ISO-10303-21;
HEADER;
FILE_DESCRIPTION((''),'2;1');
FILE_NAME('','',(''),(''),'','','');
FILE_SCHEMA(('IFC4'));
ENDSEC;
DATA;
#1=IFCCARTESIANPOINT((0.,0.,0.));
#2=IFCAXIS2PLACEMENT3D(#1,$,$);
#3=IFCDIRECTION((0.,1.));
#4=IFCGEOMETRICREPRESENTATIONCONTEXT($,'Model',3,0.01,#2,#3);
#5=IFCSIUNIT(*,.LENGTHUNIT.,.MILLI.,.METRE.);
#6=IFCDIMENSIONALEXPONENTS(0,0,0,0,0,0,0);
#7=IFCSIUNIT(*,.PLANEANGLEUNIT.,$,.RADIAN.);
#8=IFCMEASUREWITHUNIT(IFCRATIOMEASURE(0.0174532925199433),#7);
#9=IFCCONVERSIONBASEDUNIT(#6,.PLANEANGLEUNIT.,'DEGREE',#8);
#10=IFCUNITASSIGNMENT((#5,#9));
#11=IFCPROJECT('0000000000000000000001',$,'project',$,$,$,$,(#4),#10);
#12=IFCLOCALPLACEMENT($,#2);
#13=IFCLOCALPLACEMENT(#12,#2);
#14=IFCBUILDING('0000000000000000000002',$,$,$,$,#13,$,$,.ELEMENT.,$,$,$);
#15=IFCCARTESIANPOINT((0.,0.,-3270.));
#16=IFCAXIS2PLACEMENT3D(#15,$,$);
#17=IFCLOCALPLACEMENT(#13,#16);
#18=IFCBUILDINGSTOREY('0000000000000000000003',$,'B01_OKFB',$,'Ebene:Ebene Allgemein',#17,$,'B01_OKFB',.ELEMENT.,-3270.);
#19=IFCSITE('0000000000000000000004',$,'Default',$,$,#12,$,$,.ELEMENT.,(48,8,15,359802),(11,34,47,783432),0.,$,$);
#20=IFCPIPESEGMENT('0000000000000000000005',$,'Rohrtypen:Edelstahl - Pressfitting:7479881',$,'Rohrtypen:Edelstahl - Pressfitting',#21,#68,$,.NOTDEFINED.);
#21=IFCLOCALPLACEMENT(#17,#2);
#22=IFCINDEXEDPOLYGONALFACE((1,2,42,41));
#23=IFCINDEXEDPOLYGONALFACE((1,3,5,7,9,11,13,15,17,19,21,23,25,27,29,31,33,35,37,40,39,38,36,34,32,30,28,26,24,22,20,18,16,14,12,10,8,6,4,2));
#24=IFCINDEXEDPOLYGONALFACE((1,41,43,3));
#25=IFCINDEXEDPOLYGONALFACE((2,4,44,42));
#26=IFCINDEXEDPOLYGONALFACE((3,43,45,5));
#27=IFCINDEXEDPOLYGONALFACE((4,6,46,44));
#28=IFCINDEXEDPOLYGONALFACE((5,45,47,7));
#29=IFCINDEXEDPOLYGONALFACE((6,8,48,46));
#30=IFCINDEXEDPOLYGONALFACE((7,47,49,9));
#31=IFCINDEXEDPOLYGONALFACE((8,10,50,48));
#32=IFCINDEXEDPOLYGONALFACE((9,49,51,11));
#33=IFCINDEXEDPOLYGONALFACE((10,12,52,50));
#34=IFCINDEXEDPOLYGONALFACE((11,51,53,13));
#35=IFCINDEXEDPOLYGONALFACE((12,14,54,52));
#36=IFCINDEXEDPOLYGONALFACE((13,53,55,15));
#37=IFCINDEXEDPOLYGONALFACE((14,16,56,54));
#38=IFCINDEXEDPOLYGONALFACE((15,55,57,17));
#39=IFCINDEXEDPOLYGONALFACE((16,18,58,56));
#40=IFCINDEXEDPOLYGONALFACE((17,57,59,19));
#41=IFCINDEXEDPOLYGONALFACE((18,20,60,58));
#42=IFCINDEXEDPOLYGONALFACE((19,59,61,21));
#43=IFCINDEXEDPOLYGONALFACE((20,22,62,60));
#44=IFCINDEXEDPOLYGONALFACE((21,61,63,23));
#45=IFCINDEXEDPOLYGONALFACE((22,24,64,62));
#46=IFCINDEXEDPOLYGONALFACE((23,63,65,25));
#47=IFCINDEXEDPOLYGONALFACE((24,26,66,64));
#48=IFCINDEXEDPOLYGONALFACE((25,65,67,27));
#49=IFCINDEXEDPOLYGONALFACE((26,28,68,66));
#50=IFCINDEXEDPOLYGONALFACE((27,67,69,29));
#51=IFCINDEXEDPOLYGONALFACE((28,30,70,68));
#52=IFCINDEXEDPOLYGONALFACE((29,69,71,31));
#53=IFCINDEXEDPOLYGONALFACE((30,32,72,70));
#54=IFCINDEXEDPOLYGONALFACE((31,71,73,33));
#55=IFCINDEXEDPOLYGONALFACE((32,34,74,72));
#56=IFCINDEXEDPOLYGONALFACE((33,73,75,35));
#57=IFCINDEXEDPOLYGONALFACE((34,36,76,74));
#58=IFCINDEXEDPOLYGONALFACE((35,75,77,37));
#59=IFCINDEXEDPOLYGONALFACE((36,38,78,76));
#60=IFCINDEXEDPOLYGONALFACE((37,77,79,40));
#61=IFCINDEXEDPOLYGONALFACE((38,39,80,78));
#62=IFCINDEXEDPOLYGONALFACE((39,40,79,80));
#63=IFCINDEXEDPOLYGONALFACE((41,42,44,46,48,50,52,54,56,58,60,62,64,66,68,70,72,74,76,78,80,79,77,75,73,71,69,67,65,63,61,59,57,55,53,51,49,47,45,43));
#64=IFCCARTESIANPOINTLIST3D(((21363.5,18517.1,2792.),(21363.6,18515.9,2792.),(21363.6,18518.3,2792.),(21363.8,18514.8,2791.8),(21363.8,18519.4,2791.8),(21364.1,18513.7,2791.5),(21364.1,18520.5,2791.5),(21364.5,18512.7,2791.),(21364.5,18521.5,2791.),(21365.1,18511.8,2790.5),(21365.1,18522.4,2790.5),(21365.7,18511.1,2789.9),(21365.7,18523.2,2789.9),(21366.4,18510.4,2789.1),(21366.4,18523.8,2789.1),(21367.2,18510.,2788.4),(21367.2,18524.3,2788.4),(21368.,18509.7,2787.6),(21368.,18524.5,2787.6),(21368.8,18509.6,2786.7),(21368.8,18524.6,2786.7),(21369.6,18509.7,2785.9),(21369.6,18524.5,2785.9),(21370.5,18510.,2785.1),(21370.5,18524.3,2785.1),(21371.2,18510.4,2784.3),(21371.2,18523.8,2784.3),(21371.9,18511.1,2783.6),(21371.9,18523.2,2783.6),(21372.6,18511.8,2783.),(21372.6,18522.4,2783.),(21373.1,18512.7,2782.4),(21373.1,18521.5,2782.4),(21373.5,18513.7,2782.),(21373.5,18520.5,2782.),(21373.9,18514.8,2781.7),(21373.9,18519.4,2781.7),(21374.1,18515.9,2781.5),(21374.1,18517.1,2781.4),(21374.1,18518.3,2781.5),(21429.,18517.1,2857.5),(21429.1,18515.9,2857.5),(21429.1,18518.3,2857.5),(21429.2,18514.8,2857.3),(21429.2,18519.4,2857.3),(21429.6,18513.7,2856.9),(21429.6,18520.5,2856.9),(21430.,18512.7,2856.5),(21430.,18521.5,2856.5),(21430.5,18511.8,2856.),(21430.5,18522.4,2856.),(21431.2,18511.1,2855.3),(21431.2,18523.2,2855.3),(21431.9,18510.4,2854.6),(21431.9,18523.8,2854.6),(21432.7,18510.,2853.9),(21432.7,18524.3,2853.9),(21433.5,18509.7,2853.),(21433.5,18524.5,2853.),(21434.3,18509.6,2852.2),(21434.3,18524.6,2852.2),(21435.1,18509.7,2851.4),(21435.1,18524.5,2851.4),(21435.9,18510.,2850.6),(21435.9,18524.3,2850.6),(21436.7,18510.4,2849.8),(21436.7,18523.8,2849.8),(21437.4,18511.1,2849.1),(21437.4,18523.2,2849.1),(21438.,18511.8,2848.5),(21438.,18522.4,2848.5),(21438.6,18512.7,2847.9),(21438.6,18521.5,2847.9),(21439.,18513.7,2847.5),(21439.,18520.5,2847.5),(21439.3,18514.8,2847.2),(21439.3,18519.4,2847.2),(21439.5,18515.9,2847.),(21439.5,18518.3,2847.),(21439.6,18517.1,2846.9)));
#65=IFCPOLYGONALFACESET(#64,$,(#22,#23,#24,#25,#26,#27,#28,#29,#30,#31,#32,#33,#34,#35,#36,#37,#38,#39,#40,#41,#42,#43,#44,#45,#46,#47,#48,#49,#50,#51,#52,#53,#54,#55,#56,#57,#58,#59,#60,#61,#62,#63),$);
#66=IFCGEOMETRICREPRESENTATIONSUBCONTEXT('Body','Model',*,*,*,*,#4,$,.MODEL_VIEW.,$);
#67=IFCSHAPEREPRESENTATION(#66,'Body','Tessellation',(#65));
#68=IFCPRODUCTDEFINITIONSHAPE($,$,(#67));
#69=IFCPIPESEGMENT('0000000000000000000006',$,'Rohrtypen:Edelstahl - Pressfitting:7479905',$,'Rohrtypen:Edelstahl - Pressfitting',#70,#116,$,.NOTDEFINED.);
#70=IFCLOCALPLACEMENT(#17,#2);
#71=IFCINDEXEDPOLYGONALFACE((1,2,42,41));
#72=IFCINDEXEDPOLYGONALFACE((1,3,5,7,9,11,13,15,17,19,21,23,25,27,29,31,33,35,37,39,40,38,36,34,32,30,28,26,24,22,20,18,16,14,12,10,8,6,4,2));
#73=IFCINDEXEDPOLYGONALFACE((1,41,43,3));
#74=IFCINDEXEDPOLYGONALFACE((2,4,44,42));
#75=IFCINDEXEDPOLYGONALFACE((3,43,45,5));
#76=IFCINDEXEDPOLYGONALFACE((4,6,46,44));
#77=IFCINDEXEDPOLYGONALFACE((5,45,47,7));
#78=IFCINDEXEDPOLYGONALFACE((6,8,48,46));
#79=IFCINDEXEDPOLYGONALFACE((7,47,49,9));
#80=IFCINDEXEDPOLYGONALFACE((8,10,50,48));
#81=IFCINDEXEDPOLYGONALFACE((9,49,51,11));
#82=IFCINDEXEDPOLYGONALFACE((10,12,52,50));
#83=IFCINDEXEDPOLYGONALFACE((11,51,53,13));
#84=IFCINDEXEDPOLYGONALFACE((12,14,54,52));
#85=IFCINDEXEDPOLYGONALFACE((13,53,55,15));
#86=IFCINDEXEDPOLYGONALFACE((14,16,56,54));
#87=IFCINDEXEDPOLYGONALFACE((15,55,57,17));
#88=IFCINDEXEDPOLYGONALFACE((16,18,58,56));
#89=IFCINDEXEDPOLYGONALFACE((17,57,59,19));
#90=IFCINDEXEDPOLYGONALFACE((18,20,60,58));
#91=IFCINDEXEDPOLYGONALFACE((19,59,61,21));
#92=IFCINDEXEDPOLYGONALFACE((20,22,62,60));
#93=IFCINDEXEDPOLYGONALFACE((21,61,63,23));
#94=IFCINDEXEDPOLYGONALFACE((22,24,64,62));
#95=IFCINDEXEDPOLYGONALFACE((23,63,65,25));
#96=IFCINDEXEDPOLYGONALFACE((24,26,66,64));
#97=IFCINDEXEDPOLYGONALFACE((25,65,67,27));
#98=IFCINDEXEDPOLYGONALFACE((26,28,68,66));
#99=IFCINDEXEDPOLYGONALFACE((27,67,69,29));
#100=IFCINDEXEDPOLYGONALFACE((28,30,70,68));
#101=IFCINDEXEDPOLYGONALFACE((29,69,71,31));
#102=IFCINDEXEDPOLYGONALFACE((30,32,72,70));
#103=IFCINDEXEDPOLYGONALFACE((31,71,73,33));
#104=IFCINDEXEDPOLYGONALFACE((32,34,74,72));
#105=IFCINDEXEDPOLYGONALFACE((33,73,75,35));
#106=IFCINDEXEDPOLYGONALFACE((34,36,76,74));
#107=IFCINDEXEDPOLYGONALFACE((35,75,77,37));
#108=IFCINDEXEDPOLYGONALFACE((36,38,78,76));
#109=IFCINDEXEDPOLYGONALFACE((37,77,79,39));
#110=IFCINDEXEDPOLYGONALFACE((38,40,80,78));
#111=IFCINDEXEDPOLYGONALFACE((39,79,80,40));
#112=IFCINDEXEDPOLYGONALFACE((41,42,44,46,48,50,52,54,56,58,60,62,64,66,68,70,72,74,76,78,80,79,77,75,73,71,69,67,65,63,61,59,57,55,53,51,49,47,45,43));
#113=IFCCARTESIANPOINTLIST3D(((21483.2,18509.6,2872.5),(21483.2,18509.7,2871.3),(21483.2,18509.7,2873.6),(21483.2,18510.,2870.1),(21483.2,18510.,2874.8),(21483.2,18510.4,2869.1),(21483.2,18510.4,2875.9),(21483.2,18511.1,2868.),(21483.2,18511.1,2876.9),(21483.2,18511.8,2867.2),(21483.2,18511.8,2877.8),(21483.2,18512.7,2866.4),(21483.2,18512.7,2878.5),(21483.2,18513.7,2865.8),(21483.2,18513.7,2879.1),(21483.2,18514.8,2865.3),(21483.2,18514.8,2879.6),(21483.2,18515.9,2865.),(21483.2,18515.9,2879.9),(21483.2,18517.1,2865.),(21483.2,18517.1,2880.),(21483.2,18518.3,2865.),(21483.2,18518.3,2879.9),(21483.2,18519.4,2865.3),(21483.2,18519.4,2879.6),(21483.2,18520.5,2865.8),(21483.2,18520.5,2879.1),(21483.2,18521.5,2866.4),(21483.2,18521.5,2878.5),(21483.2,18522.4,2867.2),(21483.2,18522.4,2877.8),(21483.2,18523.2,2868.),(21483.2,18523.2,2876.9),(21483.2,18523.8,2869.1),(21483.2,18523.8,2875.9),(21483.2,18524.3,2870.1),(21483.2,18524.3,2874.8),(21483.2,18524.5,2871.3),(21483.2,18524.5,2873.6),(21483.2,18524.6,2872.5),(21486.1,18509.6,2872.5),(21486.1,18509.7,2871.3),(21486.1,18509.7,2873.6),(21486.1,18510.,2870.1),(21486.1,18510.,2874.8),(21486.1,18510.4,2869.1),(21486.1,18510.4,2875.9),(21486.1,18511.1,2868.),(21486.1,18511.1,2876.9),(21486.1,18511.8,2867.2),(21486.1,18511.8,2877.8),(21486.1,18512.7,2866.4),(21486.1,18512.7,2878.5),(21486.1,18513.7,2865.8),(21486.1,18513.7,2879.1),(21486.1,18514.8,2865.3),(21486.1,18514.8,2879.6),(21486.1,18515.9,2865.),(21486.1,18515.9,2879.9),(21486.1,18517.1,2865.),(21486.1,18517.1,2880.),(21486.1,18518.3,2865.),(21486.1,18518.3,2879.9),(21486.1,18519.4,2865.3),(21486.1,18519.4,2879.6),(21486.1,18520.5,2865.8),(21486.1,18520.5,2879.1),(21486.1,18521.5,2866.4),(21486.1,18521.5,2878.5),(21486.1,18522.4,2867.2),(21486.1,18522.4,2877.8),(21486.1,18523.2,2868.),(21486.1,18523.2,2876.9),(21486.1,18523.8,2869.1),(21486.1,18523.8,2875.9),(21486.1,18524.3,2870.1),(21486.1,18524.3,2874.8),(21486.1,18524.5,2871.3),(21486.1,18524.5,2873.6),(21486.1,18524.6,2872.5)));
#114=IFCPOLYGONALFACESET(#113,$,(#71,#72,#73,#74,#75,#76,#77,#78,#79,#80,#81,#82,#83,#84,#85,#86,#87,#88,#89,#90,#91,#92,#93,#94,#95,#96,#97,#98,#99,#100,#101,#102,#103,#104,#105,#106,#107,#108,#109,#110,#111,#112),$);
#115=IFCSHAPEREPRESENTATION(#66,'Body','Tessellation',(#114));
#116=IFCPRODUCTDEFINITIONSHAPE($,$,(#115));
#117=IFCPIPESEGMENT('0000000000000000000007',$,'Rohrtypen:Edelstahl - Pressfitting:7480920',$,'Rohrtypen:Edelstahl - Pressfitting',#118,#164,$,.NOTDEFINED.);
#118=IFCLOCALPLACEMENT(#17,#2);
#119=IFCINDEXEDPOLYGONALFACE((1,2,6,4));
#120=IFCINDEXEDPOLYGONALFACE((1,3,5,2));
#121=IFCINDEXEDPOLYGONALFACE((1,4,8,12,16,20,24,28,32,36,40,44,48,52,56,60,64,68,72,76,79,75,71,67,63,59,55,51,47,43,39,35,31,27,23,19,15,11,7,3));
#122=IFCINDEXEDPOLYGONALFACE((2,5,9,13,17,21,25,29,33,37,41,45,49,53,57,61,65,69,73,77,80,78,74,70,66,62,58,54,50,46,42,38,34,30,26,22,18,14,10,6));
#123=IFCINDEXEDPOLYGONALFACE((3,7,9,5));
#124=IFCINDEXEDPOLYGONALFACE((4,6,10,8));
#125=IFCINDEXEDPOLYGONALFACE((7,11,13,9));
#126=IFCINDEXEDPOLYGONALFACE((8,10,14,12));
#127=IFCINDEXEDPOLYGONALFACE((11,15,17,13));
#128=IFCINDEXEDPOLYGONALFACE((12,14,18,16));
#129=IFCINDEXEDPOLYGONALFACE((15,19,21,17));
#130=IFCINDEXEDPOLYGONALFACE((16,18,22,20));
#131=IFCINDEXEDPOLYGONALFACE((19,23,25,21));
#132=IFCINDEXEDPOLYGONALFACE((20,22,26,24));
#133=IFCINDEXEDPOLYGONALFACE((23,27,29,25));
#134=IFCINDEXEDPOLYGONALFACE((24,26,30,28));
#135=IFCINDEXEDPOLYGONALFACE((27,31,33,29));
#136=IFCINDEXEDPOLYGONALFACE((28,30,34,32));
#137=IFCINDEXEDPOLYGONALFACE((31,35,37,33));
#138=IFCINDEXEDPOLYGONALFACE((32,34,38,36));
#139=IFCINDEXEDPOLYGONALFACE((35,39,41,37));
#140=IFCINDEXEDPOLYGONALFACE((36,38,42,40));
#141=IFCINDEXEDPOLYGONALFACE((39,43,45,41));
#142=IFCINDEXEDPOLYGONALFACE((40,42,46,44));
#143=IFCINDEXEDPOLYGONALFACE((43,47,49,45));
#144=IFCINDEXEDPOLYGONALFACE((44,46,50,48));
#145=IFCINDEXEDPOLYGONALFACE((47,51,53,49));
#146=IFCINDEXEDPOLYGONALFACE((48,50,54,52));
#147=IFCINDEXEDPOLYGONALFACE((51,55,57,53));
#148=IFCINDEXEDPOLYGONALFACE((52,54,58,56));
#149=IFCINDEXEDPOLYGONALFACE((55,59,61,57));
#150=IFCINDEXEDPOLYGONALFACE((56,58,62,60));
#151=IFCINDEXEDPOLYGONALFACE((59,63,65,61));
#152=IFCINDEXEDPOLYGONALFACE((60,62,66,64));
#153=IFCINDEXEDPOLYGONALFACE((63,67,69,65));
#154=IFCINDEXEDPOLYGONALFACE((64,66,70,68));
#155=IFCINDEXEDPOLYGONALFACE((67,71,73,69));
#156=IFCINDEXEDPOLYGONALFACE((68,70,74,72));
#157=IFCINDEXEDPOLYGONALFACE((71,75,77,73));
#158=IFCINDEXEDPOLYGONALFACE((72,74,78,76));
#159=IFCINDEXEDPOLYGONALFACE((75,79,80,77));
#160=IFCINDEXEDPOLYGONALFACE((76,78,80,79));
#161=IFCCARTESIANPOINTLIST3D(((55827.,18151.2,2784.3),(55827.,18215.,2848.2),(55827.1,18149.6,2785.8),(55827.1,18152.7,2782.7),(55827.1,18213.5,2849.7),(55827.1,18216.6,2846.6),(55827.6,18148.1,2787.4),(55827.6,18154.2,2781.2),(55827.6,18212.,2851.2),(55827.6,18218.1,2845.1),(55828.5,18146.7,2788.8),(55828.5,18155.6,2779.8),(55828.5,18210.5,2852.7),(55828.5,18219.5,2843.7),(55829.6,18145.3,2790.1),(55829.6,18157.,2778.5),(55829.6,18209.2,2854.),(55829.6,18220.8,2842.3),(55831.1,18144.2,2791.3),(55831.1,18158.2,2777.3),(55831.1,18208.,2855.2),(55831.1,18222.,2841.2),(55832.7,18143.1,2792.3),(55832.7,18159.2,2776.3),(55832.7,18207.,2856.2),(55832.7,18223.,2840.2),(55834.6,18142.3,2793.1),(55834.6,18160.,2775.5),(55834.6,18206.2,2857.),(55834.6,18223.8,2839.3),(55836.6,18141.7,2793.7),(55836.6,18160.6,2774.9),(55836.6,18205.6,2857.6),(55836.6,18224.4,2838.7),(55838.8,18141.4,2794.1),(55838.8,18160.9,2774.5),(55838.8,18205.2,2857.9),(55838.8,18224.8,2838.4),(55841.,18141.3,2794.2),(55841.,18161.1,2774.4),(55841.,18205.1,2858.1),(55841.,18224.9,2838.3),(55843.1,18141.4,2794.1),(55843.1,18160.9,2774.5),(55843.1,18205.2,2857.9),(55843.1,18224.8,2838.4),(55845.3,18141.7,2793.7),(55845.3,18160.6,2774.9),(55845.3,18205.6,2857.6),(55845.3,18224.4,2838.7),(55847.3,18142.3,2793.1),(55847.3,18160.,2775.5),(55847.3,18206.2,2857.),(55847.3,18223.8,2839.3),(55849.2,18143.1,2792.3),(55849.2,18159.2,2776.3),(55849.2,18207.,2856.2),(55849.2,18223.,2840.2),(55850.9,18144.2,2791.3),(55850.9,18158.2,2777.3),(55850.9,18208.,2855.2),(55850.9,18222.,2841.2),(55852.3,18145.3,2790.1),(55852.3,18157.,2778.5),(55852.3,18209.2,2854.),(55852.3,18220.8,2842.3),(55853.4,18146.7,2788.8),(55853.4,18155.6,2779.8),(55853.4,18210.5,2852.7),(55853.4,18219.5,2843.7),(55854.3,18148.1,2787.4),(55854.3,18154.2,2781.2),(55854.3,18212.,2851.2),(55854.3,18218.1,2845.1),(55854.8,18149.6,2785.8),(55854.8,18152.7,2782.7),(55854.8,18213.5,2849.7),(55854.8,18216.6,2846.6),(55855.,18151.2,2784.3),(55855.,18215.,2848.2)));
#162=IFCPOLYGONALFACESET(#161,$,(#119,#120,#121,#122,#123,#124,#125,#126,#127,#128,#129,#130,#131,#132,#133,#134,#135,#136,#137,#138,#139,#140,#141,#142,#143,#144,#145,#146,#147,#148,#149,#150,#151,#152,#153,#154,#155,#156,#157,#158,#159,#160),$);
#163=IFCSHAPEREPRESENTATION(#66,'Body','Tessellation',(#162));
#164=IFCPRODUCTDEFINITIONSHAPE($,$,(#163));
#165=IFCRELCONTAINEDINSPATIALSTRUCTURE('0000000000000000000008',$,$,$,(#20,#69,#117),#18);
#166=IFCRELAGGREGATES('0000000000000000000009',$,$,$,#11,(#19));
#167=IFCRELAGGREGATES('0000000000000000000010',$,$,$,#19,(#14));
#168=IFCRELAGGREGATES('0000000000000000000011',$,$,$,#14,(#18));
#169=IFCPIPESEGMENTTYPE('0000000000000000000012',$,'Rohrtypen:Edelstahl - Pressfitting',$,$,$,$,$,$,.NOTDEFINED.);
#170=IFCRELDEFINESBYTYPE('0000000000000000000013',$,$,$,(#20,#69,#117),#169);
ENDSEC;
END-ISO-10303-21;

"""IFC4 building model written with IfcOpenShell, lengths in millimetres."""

from ifc_helpers import new_model, entity, si_unit, converted_unit, direction, frame, origin, place, context, subcontext, project, spatial, indexed_curve, outline, extrude, type_object, element, save


model = new_model("IFC4")

# Units and contexts
model_context = context("Model", 3, precision=0.01, world=origin(), true_north=direction((0.0, 1.0)))
body_context = subcontext(model_context, "Body", "Model", "MODEL_VIEW")
ifc_project = project(units=[si_unit("LENGTHUNIT", "METRE", prefix="MILLI"), converted_unit("PLANEANGLEUNIT", "DEGREE", entity("IfcRatioMeasure", 0.0174532925199433), si_unit("PLANEANGLEUNIT", "RADIAN"), dimensions=[0, 0, 0, 0, 0, 0, 0])], contexts=[model_context])

# Site, building, storey
site_placement = place(None, origin())
site = spatial("IfcSite", under=ifc_project, at=site_placement, Name="Default", CompositionType="ELEMENT", RefLatitude=(48, 8, 15, 359802), RefLongitude=(11, 34, 47, 783432), RefElevation=0.0)
building_placement = place(site_placement, origin())
building = spatial("IfcBuilding", under=site, at=building_placement, CompositionType="ELEMENT")
storey_placement = place(building_placement, frame((0.0, 0.0, -3270.0)))
storey = spatial("IfcBuildingStorey", under=building, at=storey_placement, Name="B01_OKFB", ObjectType="Ebene:Ebene Allgemein", LongName="B01_OKFB", CompositionType="ELEMENT", Elevation=-3270.0)

# Pipe segments
pipe_segment_type_1 = type_object("IfcPipeSegmentType", Name="Rohrtypen:Edelstahl - Pressfitting", PredefinedType="NOTDEFINED")
pipe_segment_1_placement = place(storey_placement, origin())
element("IfcPipeSegment", 1, at=pipe_segment_1_placement, inside=storey, type_object=pipe_segment_type_1, Name="Rohrtypen:Edelstahl - Pressfitting:7479881", ObjectType="Rohrtypen:Edelstahl - Pressfitting", PredefinedType="NOTDEFINED", context=body_context, shape_type="SweptSolid", body=[
    extrude(outline(indexed_curve([(7.5, 0.0), (7.4, 1.2), (7.1, 2.3), (6.7, 3.4), (6.1, 4.4), (5.3, 5.3), (4.4, 6.1), (3.4, 6.7), (2.3, 7.1), (1.2, 7.4), (0.0, 7.5), (-1.2, 7.4), (-2.3, 7.1), (-3.4, 6.7), (-4.4, 6.1), (-5.3, 5.3), (-6.1, 4.4), (-6.7, 3.4), (-7.1, 2.3), (-7.4, 1.2), (-7.5, 0.0), (-7.4, -1.2), (-7.1, -2.3), (-6.7, -3.4), (-6.1, -4.4), (-5.3, -5.3), (-4.4, -6.1), (-3.4, -6.7), (-2.3, -7.1), (-1.2, -7.4), (0.0, -7.5), (1.2, -7.4), (2.3, -7.1), (3.4, -6.7), (4.4, -6.1), (5.3, -5.3), (6.1, -4.4), (6.7, -3.4), (7.1, -2.3), (7.4, -1.2), (7.5, 0.0)], self_intersect=False)), frame((21368.8, 18517.1, 2786.7), z_axis=(0.707107, 0.0, 0.707107), x_axis=(0.0, -1.0, 0.0)), (0.0, 0.0, 1.0), 92.6),
])
pipe_segment_2_placement = place(storey_placement, origin())
element("IfcPipeSegment", 2, at=pipe_segment_2_placement, inside=storey, type_object=pipe_segment_type_1, Name="Rohrtypen:Edelstahl - Pressfitting:7479905", ObjectType="Rohrtypen:Edelstahl - Pressfitting", PredefinedType="NOTDEFINED", context=body_context, shape_type="SweptSolid", body=[
    extrude(outline(indexed_curve([(7.5, 0.0), (7.4, 1.2), (7.1, 2.3), (6.7, 3.4), (6.1, 4.4), (5.3, 5.3), (4.4, 6.1), (3.4, 6.7), (2.3, 7.1), (1.2, 7.4), (0.0, 7.5), (-1.2, 7.4), (-2.3, 7.1), (-3.4, 6.7), (-4.4, 6.1), (-5.3, 5.3), (-6.1, 4.4), (-6.7, 3.4), (-7.1, 2.3), (-7.4, 1.2), (-7.5, 0.0), (-7.4, -1.2), (-7.1, -2.3), (-6.7, -3.4), (-6.1, -4.4), (-5.3, -5.3), (-4.4, -6.1), (-3.4, -6.7), (-2.3, -7.1), (-1.2, -7.4), (0.0, -7.5), (1.2, -7.4), (2.3, -7.1), (3.4, -6.7), (4.4, -6.1), (5.3, -5.3), (6.1, -4.4), (6.7, -3.4), (7.1, -2.3), (7.4, -1.2), (7.5, 0.0)], self_intersect=False)), frame((21483.2, 18517.1, 2872.5), z_axis=(1.0, 0.0, 0.0), x_axis=(0.0, 1.0, 0.0)), (0.0, 0.0, 1.0), 2.9),
])
pipe_segment_3_placement = place(storey_placement, origin())
element("IfcPipeSegment", 3, at=pipe_segment_3_placement, inside=storey, type_object=pipe_segment_type_1, Name="Rohrtypen:Edelstahl - Pressfitting:7480920", ObjectType="Rohrtypen:Edelstahl - Pressfitting", PredefinedType="NOTDEFINED", context=body_context, shape_type="SweptSolid", body=[
    extrude(outline(indexed_curve([(14.0, 0.0), (13.8, 2.2), (13.3, 4.3), (12.5, 6.4), (11.3, 8.2), (9.9, 9.9), (8.2, 11.3), (6.4, 12.5), (4.3, 13.3), (2.2, 13.8), (0.0, 14.0), (-2.2, 13.8), (-4.3, 13.3), (-6.4, 12.5), (-8.2, 11.3), (-9.9, 9.9), (-11.3, 8.2), (-12.5, 6.4), (-13.3, 4.3), (-13.8, 2.2), (-14.0, 0.0), (-13.8, -2.2), (-13.3, -4.3), (-12.5, -6.4), (-11.3, -8.2), (-9.9, -9.9), (-8.2, -11.3), (-6.4, -12.5), (-4.3, -13.3), (-2.2, -13.8), (0.0, -14.0), (2.2, -13.8), (4.3, -13.3), (6.4, -12.5), (8.2, -11.3), (9.9, -9.9), (11.3, -8.2), (12.5, -6.4), (13.3, -4.3), (13.8, -2.2), (14.0, 0.0)], self_intersect=False)), frame((55841.0, 18151.2, 2784.3), z_axis=(0.0, 0.707107, 0.707107), x_axis=(-1.0, 0.0, 0.0)), (0.0, 0.0, 1.0), 90.3),
])

save(model, "model.ifc")
